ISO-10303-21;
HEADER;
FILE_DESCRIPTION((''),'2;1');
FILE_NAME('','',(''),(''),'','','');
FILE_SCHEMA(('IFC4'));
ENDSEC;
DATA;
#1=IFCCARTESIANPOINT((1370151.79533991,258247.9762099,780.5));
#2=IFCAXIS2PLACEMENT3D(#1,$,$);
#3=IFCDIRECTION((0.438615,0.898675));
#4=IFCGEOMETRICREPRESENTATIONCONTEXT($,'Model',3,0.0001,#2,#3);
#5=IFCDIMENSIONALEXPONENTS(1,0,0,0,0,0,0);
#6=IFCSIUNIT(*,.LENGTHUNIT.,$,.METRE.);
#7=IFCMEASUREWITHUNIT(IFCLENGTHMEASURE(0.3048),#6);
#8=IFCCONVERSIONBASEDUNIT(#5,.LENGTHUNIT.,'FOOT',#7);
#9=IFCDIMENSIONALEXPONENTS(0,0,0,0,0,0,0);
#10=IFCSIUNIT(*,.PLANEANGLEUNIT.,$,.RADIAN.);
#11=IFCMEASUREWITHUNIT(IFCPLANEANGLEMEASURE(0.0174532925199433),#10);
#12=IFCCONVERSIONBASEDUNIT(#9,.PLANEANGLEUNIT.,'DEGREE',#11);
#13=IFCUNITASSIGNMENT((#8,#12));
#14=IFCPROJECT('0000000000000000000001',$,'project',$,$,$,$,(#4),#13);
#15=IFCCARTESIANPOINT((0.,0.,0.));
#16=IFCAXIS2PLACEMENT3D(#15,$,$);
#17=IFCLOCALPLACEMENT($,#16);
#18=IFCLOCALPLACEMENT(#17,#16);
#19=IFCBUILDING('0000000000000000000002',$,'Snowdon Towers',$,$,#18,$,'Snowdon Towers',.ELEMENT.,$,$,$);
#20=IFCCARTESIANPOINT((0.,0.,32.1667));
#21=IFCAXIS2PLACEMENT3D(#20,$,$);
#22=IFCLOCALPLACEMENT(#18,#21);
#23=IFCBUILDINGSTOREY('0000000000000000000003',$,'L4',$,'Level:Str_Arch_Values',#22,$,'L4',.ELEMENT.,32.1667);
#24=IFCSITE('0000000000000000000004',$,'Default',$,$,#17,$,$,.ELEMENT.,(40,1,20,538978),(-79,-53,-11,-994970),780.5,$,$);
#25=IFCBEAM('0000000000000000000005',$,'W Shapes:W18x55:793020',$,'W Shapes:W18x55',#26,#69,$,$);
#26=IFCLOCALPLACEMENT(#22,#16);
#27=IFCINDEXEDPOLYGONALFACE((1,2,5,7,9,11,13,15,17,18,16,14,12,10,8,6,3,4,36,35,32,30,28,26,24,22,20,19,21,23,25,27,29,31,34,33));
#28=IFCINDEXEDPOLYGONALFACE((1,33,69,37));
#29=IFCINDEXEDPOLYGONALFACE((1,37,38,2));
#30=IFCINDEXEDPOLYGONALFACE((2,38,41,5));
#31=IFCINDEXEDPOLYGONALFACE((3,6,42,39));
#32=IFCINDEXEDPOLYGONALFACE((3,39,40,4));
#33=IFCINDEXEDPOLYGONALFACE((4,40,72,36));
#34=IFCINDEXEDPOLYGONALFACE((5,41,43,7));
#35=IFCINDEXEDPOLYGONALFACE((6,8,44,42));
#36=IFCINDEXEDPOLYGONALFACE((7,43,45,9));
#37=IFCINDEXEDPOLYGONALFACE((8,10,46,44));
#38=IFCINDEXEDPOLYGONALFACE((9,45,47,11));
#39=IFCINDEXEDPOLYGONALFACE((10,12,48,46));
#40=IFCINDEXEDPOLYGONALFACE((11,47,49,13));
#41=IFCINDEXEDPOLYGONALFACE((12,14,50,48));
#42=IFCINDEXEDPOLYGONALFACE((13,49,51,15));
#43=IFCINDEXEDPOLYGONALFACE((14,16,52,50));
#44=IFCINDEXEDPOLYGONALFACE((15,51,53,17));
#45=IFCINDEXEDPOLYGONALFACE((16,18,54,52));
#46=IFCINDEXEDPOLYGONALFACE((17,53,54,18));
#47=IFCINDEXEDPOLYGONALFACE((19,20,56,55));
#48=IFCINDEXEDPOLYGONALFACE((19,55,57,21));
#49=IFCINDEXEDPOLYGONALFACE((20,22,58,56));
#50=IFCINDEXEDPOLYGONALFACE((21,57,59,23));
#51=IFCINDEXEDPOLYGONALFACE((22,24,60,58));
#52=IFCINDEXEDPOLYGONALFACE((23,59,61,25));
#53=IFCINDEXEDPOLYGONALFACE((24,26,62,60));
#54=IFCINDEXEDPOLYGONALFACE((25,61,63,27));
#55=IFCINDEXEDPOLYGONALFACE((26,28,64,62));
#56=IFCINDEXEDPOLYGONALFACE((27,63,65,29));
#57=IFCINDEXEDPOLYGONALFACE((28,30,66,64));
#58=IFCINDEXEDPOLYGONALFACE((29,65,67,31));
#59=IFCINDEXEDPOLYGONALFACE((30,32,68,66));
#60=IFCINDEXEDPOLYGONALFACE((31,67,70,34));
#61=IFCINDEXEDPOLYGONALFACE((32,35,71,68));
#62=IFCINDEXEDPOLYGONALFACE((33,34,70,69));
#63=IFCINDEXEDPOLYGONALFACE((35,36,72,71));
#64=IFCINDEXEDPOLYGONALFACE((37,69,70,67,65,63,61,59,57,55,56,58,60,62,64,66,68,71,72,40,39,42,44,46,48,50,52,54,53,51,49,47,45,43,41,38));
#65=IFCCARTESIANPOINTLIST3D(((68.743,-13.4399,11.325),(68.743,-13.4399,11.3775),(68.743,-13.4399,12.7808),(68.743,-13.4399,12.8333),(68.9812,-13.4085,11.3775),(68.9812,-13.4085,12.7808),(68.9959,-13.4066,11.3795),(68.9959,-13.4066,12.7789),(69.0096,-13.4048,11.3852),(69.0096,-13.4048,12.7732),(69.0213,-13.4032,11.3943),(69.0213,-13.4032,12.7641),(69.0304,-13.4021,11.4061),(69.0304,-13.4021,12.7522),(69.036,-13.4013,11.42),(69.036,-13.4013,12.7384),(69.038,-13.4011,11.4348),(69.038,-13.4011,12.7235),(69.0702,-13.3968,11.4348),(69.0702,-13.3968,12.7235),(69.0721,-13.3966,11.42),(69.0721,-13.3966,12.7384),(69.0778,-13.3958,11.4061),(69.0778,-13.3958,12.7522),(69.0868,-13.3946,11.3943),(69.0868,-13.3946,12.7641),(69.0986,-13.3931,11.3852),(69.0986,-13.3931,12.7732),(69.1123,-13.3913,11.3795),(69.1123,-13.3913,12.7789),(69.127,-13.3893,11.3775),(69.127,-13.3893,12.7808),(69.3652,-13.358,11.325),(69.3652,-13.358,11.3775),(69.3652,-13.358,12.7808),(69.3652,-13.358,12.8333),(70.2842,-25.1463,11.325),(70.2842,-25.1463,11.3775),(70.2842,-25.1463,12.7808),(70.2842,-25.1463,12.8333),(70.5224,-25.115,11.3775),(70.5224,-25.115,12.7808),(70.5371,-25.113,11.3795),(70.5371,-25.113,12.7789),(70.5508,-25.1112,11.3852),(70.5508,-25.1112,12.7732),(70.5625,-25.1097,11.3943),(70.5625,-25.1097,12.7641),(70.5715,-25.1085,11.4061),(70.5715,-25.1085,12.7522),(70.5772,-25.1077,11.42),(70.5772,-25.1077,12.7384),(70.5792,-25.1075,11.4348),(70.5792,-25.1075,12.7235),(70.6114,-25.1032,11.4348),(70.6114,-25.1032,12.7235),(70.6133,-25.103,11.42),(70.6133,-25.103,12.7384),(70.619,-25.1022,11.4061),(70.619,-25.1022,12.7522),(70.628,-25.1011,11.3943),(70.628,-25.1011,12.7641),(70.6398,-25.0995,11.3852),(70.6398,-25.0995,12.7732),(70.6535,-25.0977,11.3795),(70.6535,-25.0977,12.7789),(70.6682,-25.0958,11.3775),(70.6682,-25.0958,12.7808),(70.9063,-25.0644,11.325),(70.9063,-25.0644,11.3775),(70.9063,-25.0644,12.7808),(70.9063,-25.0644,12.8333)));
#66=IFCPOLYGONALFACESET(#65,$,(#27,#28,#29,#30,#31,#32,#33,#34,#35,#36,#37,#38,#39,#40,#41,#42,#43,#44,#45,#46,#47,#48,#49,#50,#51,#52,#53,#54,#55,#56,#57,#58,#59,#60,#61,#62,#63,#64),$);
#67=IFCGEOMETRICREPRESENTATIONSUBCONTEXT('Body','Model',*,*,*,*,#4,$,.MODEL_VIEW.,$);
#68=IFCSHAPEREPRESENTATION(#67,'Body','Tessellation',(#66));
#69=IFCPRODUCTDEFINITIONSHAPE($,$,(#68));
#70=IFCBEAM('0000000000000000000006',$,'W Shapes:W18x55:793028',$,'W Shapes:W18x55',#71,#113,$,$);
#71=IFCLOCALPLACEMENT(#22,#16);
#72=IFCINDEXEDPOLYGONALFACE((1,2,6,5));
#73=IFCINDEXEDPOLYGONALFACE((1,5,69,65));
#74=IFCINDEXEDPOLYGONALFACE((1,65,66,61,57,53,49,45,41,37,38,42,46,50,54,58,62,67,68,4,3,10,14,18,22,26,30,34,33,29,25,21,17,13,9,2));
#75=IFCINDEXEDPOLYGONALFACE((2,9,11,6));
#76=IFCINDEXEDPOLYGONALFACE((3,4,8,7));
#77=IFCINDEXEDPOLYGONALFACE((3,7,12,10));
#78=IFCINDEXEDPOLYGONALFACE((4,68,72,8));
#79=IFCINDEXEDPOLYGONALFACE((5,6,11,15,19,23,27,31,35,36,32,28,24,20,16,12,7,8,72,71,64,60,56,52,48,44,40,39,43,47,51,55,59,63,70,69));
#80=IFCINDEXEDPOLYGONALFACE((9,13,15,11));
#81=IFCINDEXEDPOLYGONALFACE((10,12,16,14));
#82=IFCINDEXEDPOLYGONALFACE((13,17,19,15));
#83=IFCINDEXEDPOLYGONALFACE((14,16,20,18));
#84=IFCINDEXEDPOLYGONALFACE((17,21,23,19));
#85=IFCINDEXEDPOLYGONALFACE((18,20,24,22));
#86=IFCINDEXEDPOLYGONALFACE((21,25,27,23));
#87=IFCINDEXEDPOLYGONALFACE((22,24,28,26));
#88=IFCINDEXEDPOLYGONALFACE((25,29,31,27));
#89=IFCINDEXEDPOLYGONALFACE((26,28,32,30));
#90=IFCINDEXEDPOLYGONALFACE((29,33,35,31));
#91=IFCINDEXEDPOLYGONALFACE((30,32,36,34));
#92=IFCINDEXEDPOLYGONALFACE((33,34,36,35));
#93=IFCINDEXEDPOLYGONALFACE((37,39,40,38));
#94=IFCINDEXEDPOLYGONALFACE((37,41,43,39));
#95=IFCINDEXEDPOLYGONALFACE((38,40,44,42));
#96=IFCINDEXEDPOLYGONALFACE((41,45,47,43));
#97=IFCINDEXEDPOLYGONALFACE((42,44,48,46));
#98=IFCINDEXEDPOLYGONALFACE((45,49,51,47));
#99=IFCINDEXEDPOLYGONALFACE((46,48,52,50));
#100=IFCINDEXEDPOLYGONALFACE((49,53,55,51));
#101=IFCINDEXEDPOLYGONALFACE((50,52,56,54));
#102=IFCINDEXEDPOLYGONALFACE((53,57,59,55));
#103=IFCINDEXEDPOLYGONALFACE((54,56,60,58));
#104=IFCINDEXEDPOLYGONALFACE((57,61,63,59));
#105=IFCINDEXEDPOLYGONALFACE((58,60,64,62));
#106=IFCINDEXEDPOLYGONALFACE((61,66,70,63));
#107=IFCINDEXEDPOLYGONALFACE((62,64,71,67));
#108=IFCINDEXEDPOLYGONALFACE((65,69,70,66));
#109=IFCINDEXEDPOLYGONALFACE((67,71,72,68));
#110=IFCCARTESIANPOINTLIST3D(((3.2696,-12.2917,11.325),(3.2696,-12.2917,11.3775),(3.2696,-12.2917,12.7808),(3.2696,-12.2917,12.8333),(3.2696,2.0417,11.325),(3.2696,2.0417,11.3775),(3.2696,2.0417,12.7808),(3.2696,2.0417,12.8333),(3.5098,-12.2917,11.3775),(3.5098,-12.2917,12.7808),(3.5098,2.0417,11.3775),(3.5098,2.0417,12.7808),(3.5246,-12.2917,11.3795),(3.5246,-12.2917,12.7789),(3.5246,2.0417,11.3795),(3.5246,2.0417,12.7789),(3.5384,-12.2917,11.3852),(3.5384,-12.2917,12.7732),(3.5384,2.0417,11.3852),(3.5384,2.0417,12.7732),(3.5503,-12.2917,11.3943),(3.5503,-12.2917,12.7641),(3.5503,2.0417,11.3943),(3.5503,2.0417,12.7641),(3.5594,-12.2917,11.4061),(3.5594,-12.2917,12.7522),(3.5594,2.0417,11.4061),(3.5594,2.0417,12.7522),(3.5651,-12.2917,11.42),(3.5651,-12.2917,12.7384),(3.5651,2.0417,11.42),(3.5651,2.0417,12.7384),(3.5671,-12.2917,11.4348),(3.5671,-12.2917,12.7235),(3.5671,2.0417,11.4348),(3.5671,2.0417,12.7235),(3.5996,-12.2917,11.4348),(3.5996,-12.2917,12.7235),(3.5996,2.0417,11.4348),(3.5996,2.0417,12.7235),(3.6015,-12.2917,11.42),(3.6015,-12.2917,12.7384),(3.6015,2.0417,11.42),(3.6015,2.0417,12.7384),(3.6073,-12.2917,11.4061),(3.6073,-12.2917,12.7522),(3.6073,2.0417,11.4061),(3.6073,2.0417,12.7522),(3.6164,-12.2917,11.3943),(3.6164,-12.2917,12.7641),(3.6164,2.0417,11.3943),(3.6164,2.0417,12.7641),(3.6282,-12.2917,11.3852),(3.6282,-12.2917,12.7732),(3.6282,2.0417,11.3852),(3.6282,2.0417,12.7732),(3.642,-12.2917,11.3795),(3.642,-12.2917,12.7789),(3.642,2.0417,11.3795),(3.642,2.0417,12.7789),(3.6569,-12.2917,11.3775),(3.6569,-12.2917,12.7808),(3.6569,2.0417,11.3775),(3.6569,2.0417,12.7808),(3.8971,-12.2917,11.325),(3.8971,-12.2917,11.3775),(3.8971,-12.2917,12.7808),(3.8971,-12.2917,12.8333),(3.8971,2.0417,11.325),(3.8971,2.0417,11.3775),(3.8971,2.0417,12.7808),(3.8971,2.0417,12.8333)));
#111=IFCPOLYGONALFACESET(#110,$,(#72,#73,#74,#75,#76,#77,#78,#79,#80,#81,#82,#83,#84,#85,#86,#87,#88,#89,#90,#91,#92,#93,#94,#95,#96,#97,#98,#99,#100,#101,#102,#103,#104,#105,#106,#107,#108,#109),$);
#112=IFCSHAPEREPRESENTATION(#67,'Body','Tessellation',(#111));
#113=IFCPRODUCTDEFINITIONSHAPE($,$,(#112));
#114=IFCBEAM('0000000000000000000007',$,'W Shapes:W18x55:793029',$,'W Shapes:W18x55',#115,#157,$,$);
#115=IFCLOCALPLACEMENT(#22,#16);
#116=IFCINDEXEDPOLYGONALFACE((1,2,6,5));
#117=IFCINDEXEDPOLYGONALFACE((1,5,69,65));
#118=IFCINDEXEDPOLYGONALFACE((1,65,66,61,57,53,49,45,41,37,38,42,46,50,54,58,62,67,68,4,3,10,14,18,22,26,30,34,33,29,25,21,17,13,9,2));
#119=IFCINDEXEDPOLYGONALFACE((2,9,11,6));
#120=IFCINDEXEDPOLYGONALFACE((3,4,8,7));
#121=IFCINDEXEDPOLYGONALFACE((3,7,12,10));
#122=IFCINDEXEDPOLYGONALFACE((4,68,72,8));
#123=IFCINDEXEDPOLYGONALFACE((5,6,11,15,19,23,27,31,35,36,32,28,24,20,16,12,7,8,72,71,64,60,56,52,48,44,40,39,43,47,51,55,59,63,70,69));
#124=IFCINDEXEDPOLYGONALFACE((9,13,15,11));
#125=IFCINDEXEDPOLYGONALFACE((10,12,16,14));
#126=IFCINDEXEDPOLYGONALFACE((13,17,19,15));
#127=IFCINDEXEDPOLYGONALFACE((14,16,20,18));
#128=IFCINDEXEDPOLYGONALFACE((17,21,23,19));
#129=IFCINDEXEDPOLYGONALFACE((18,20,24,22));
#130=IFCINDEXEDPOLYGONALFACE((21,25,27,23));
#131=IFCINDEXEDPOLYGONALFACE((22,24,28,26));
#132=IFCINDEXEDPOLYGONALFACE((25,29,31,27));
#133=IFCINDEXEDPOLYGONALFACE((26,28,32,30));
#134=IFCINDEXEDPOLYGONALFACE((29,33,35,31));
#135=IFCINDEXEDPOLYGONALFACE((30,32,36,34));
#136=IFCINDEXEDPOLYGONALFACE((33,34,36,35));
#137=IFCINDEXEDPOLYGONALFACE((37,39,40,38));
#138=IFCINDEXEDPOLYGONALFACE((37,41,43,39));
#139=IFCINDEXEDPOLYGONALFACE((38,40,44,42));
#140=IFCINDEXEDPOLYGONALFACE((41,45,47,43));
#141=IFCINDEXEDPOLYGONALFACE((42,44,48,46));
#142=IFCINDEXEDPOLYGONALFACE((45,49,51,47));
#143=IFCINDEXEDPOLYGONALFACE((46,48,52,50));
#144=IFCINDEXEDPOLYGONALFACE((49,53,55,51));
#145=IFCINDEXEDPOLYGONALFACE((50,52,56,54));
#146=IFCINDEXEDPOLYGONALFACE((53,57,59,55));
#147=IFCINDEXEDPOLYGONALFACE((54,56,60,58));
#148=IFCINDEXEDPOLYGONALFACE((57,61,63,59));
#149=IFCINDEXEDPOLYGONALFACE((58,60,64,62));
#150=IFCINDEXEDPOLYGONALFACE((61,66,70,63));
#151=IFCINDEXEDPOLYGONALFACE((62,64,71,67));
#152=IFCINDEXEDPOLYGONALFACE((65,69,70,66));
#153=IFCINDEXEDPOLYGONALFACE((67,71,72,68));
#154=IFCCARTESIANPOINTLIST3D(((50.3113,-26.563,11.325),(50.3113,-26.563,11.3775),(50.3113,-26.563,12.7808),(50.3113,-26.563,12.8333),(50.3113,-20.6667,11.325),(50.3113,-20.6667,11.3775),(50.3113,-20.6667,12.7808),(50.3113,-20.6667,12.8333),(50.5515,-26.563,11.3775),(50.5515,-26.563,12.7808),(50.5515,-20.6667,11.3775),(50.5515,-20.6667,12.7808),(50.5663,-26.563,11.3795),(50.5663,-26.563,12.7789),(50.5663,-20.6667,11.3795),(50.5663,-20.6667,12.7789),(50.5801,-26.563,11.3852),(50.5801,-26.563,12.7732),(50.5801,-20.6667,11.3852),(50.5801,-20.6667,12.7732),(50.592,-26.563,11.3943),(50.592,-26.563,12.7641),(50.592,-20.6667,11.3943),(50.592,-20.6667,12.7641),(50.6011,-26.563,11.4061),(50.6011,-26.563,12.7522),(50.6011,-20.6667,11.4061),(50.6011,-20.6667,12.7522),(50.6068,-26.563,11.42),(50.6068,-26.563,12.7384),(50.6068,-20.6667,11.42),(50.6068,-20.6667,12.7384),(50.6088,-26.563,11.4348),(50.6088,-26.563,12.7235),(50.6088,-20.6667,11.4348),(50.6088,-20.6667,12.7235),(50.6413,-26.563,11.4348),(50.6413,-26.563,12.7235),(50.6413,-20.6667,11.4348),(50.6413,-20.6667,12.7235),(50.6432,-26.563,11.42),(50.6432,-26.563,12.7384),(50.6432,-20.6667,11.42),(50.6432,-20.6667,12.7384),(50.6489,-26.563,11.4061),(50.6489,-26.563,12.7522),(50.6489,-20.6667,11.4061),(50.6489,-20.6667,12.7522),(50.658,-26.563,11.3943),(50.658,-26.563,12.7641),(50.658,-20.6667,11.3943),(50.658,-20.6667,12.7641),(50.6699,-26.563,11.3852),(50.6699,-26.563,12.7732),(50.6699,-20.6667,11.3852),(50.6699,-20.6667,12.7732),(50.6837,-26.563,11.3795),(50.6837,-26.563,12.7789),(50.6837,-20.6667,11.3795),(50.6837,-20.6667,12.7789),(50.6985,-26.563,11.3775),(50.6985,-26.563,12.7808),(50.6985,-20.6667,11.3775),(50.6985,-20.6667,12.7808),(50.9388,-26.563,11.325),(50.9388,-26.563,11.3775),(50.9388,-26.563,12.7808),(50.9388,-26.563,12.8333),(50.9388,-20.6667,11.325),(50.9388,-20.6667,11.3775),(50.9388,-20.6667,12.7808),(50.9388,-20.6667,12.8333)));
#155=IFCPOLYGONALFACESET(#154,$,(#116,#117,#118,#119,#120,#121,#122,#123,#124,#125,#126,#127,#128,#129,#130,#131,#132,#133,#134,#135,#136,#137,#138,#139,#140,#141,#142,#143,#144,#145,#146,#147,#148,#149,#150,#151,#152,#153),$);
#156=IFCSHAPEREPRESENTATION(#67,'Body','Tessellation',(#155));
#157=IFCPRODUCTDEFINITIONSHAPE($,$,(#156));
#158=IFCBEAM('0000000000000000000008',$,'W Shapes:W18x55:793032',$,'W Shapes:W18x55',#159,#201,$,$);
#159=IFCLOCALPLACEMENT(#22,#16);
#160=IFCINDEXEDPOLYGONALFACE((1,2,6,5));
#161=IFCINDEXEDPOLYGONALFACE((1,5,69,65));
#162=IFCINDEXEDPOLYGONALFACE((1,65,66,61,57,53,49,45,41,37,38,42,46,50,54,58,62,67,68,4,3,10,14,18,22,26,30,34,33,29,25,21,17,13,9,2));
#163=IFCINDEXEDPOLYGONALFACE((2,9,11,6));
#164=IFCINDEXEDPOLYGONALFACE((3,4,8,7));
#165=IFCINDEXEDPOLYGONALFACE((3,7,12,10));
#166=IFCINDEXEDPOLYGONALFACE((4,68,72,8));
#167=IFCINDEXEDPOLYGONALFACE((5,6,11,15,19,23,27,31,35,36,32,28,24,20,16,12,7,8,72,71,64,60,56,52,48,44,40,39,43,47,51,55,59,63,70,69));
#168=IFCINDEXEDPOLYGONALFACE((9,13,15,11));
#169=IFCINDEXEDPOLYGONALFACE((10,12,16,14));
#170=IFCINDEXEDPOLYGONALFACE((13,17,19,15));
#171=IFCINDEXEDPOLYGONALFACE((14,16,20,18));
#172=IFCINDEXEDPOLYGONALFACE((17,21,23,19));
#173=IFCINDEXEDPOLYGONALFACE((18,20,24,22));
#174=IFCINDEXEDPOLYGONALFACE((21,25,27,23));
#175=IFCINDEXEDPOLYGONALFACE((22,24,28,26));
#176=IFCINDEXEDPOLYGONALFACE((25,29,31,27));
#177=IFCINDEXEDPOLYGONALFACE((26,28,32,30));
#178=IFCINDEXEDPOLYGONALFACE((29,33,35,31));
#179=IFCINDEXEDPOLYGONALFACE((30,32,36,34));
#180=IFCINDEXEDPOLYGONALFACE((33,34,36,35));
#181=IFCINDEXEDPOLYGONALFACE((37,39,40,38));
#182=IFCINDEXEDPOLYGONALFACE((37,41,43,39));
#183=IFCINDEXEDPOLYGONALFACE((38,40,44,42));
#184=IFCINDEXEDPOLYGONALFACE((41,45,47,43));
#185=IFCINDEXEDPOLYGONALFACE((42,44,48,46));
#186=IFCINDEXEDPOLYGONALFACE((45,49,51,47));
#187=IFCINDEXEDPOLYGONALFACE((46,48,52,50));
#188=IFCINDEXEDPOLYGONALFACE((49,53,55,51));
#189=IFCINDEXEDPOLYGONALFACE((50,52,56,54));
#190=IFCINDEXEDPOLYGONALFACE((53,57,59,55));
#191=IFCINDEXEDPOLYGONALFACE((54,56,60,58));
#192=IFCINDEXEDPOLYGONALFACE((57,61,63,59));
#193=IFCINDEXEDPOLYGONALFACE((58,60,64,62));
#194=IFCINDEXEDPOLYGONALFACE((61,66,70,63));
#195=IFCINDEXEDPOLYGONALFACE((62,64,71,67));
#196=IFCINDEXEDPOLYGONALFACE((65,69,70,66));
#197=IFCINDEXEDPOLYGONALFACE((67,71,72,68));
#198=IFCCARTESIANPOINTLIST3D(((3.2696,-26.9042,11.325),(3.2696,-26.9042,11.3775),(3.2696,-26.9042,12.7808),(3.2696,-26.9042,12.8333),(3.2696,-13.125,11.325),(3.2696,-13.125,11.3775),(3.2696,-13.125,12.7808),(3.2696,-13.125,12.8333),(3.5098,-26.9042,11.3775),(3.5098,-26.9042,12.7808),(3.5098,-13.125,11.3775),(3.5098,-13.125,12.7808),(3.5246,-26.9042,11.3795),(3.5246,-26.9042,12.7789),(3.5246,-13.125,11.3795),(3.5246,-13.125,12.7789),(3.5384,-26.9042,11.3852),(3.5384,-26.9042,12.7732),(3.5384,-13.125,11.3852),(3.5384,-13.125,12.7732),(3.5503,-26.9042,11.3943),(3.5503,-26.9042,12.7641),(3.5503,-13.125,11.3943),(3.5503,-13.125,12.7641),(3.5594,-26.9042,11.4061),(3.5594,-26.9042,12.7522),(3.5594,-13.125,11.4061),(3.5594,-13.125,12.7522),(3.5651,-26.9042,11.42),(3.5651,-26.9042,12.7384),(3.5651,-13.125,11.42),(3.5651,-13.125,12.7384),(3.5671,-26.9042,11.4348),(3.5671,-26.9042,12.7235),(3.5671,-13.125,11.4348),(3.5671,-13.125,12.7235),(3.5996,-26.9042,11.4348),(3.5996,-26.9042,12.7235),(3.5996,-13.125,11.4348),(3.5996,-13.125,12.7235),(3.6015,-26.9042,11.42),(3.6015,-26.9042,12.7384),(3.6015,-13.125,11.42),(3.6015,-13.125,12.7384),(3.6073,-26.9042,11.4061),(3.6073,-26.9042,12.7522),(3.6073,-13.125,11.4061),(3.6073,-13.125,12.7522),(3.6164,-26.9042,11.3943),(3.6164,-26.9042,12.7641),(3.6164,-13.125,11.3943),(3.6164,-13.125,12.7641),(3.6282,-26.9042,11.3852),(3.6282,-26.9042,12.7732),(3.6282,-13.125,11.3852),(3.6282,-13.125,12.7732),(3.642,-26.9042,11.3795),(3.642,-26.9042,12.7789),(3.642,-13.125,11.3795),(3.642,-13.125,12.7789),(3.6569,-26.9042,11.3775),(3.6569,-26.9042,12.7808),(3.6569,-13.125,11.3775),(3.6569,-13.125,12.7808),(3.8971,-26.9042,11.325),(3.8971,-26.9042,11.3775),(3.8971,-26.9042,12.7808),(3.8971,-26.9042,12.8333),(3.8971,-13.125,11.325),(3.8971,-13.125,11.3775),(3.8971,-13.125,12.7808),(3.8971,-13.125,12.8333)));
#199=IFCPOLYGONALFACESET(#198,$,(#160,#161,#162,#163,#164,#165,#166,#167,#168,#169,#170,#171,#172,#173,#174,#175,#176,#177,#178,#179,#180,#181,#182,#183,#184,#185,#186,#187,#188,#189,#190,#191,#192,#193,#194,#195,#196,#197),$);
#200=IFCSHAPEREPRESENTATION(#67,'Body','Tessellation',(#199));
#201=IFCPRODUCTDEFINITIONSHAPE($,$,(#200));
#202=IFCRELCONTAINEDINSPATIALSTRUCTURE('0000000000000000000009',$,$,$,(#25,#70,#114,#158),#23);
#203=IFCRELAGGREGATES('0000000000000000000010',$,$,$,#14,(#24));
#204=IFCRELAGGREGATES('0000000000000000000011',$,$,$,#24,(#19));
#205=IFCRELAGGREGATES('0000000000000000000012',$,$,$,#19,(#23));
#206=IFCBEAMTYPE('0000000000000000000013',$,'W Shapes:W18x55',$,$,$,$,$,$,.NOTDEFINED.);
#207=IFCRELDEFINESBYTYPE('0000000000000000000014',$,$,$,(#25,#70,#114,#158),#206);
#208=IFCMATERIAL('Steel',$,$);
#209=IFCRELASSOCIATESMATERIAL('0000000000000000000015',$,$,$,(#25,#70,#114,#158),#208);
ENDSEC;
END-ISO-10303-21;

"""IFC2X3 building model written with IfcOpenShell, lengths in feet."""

from ifc_helpers import new_model, entity, si_unit, converted_unit, direction, frame, frame_2d, origin, place, context, subcontext, project, spatial, i_section, extrude, material, type_object, element, save


model = new_model("IFC2X3")

# Units and contexts
model_context = context("Model", 3, precision=0.0001, world=frame((1370151.79533991, 258247.9762099, 780.5)), true_north=direction((0.438615, 0.898675)))
body_context = subcontext(model_context, "Body", "Model", "MODEL_VIEW")
ifc_project = project(units=[converted_unit("LENGTHUNIT", "FOOT", entity("IfcLengthMeasure", 0.3048), si_unit("LENGTHUNIT", "METRE"), dimensions=[1, 0, 0, 0, 0, 0, 0]), converted_unit("PLANEANGLEUNIT", "DEGREE", entity("IfcPlaneAngleMeasure", 0.0174532925199433), si_unit("PLANEANGLEUNIT", "RADIAN"), dimensions=[0, 0, 0, 0, 0, 0, 0])], contexts=[model_context])

# Site, building, storey
site_placement = place(None, origin())
site = spatial("IfcSite", under=ifc_project, at=site_placement, Name="Default", CompositionType="ELEMENT", RefLatitude=(40, 1, 20, 538978), RefLongitude=(-79, -53, -11, -994970), RefElevation=780.5)
building_placement = place(site_placement, origin())
building = spatial("IfcBuilding", under=site, at=building_placement, Name="Snowdon Towers", LongName="Snowdon Towers", CompositionType="ELEMENT")
storey_placement = place(building_placement, frame((0.0, 0.0, 32.1667)))
storey = spatial("IfcBuildingStorey", under=building, at=storey_placement, Name="L4", ObjectType="Level:Str_Arch_Values", LongName="L4", CompositionType="ELEMENT", Elevation=32.1667)

# Beams
ifc_material = material(Name="Steel")
beam_type_1 = type_object("IfcBeamType", Name="W Shapes:W18x55", PredefinedType="NOTDEFINED")
beam_1_placement = place(storey_placement, frame((68.9732, -12.7845, 12.8333), z_axis=(0.0, 0.0, 1.0), x_axis=(0.130526, -0.991445, 0.0)))
element("IfcBeam", 1, at=beam_1_placement, inside=storey, type_object=beam_type_1, material=ifc_material, Name="W Shapes:W18x55:793020", ObjectType="W Shapes:W18x55", context=body_context, shape_type="SweptSolid", body=[
    extrude(i_section(OverallWidth=0.6275, OverallDepth=1.5083, WebThickness=0.0325, FlangeThickness=0.0525, FilletRadius=0.0573, at=frame_2d((0.0, 0.0), x_axis=(0.0, 1.0))), frame((0.6198, 0.0, -0.7542), z_axis=(1.0, 0.0, 0.0), x_axis=(0.0, 0.0, -1.0)), (0.0, 0.0, 1.0), 11.8075),
])
beam_2_placement = place(storey_placement, frame((3.5833, 2.5, 12.8333), z_axis=(0.0, 0.0, 1.0), x_axis=(0.0, -1.0, 0.0)))
element("IfcBeam", 2, at=beam_2_placement, inside=storey, type_object=beam_type_1, material=ifc_material, Name="W Shapes:W18x55:793028", ObjectType="W Shapes:W18x55", context=body_context, shape_type="SweptSolid", body=[
    extrude(i_section(OverallWidth=0.6275, OverallDepth=1.5083, WebThickness=0.0325, FlangeThickness=0.0525, FilletRadius=0.0573, at=frame_2d((0.0, 0.0), x_axis=(0.0, 1.0))), frame((0.4583, 0.0, -0.7542), z_axis=(1.0, 0.0, 0.0), x_axis=(0.0, 0.0, -1.0)), (0.0, 0.0, 1.0), 14.3333),
])
beam_3_placement = place(storey_placement, frame((50.625, -20.125, 12.8333), z_axis=(0.0, 0.0, 1.0), x_axis=(0.0, -1.0, 0.0)))
element("IfcBeam", 3, at=beam_3_placement, inside=storey, type_object=beam_type_1, material=ifc_material, Name="W Shapes:W18x55:793029", ObjectType="W Shapes:W18x55", context=body_context, shape_type="SweptSolid", body=[
    extrude(i_section(OverallWidth=0.6275, OverallDepth=1.5083, WebThickness=0.0325, FlangeThickness=0.0525, FilletRadius=0.0573, at=frame_2d((0.0, 0.0), x_axis=(0.0, 1.0))), frame((0.5417, 0.0, -0.7542), z_axis=(1.0, 0.0, 0.0), x_axis=(0.0, 0.0, -1.0)), (0.0, 0.0, 1.0), 5.8964),
])
beam_4_placement = place(storey_placement, frame((3.5833, -12.7083, 12.8333), z_axis=(0.0, 0.0, 1.0), x_axis=(0.0, -1.0, 0.0)))
element("IfcBeam", 4, at=beam_4_placement, inside=storey, type_object=beam_type_1, material=ifc_material, Name="W Shapes:W18x55:793032", ObjectType="W Shapes:W18x55", context=body_context, shape_type="SweptSolid", body=[
    extrude(i_section(OverallWidth=0.6275, OverallDepth=1.5083, WebThickness=0.0325, FlangeThickness=0.0525, FilletRadius=0.0573, at=frame_2d((0.0, 0.0), x_axis=(0.0, 1.0))), frame((0.4167, 0.0, -0.7542), z_axis=(1.0, 0.0, 0.0), x_axis=(0.0, 0.0, -1.0)), (0.0, 0.0, 1.0), 13.7792),
])

save(model, "model.ifc")
